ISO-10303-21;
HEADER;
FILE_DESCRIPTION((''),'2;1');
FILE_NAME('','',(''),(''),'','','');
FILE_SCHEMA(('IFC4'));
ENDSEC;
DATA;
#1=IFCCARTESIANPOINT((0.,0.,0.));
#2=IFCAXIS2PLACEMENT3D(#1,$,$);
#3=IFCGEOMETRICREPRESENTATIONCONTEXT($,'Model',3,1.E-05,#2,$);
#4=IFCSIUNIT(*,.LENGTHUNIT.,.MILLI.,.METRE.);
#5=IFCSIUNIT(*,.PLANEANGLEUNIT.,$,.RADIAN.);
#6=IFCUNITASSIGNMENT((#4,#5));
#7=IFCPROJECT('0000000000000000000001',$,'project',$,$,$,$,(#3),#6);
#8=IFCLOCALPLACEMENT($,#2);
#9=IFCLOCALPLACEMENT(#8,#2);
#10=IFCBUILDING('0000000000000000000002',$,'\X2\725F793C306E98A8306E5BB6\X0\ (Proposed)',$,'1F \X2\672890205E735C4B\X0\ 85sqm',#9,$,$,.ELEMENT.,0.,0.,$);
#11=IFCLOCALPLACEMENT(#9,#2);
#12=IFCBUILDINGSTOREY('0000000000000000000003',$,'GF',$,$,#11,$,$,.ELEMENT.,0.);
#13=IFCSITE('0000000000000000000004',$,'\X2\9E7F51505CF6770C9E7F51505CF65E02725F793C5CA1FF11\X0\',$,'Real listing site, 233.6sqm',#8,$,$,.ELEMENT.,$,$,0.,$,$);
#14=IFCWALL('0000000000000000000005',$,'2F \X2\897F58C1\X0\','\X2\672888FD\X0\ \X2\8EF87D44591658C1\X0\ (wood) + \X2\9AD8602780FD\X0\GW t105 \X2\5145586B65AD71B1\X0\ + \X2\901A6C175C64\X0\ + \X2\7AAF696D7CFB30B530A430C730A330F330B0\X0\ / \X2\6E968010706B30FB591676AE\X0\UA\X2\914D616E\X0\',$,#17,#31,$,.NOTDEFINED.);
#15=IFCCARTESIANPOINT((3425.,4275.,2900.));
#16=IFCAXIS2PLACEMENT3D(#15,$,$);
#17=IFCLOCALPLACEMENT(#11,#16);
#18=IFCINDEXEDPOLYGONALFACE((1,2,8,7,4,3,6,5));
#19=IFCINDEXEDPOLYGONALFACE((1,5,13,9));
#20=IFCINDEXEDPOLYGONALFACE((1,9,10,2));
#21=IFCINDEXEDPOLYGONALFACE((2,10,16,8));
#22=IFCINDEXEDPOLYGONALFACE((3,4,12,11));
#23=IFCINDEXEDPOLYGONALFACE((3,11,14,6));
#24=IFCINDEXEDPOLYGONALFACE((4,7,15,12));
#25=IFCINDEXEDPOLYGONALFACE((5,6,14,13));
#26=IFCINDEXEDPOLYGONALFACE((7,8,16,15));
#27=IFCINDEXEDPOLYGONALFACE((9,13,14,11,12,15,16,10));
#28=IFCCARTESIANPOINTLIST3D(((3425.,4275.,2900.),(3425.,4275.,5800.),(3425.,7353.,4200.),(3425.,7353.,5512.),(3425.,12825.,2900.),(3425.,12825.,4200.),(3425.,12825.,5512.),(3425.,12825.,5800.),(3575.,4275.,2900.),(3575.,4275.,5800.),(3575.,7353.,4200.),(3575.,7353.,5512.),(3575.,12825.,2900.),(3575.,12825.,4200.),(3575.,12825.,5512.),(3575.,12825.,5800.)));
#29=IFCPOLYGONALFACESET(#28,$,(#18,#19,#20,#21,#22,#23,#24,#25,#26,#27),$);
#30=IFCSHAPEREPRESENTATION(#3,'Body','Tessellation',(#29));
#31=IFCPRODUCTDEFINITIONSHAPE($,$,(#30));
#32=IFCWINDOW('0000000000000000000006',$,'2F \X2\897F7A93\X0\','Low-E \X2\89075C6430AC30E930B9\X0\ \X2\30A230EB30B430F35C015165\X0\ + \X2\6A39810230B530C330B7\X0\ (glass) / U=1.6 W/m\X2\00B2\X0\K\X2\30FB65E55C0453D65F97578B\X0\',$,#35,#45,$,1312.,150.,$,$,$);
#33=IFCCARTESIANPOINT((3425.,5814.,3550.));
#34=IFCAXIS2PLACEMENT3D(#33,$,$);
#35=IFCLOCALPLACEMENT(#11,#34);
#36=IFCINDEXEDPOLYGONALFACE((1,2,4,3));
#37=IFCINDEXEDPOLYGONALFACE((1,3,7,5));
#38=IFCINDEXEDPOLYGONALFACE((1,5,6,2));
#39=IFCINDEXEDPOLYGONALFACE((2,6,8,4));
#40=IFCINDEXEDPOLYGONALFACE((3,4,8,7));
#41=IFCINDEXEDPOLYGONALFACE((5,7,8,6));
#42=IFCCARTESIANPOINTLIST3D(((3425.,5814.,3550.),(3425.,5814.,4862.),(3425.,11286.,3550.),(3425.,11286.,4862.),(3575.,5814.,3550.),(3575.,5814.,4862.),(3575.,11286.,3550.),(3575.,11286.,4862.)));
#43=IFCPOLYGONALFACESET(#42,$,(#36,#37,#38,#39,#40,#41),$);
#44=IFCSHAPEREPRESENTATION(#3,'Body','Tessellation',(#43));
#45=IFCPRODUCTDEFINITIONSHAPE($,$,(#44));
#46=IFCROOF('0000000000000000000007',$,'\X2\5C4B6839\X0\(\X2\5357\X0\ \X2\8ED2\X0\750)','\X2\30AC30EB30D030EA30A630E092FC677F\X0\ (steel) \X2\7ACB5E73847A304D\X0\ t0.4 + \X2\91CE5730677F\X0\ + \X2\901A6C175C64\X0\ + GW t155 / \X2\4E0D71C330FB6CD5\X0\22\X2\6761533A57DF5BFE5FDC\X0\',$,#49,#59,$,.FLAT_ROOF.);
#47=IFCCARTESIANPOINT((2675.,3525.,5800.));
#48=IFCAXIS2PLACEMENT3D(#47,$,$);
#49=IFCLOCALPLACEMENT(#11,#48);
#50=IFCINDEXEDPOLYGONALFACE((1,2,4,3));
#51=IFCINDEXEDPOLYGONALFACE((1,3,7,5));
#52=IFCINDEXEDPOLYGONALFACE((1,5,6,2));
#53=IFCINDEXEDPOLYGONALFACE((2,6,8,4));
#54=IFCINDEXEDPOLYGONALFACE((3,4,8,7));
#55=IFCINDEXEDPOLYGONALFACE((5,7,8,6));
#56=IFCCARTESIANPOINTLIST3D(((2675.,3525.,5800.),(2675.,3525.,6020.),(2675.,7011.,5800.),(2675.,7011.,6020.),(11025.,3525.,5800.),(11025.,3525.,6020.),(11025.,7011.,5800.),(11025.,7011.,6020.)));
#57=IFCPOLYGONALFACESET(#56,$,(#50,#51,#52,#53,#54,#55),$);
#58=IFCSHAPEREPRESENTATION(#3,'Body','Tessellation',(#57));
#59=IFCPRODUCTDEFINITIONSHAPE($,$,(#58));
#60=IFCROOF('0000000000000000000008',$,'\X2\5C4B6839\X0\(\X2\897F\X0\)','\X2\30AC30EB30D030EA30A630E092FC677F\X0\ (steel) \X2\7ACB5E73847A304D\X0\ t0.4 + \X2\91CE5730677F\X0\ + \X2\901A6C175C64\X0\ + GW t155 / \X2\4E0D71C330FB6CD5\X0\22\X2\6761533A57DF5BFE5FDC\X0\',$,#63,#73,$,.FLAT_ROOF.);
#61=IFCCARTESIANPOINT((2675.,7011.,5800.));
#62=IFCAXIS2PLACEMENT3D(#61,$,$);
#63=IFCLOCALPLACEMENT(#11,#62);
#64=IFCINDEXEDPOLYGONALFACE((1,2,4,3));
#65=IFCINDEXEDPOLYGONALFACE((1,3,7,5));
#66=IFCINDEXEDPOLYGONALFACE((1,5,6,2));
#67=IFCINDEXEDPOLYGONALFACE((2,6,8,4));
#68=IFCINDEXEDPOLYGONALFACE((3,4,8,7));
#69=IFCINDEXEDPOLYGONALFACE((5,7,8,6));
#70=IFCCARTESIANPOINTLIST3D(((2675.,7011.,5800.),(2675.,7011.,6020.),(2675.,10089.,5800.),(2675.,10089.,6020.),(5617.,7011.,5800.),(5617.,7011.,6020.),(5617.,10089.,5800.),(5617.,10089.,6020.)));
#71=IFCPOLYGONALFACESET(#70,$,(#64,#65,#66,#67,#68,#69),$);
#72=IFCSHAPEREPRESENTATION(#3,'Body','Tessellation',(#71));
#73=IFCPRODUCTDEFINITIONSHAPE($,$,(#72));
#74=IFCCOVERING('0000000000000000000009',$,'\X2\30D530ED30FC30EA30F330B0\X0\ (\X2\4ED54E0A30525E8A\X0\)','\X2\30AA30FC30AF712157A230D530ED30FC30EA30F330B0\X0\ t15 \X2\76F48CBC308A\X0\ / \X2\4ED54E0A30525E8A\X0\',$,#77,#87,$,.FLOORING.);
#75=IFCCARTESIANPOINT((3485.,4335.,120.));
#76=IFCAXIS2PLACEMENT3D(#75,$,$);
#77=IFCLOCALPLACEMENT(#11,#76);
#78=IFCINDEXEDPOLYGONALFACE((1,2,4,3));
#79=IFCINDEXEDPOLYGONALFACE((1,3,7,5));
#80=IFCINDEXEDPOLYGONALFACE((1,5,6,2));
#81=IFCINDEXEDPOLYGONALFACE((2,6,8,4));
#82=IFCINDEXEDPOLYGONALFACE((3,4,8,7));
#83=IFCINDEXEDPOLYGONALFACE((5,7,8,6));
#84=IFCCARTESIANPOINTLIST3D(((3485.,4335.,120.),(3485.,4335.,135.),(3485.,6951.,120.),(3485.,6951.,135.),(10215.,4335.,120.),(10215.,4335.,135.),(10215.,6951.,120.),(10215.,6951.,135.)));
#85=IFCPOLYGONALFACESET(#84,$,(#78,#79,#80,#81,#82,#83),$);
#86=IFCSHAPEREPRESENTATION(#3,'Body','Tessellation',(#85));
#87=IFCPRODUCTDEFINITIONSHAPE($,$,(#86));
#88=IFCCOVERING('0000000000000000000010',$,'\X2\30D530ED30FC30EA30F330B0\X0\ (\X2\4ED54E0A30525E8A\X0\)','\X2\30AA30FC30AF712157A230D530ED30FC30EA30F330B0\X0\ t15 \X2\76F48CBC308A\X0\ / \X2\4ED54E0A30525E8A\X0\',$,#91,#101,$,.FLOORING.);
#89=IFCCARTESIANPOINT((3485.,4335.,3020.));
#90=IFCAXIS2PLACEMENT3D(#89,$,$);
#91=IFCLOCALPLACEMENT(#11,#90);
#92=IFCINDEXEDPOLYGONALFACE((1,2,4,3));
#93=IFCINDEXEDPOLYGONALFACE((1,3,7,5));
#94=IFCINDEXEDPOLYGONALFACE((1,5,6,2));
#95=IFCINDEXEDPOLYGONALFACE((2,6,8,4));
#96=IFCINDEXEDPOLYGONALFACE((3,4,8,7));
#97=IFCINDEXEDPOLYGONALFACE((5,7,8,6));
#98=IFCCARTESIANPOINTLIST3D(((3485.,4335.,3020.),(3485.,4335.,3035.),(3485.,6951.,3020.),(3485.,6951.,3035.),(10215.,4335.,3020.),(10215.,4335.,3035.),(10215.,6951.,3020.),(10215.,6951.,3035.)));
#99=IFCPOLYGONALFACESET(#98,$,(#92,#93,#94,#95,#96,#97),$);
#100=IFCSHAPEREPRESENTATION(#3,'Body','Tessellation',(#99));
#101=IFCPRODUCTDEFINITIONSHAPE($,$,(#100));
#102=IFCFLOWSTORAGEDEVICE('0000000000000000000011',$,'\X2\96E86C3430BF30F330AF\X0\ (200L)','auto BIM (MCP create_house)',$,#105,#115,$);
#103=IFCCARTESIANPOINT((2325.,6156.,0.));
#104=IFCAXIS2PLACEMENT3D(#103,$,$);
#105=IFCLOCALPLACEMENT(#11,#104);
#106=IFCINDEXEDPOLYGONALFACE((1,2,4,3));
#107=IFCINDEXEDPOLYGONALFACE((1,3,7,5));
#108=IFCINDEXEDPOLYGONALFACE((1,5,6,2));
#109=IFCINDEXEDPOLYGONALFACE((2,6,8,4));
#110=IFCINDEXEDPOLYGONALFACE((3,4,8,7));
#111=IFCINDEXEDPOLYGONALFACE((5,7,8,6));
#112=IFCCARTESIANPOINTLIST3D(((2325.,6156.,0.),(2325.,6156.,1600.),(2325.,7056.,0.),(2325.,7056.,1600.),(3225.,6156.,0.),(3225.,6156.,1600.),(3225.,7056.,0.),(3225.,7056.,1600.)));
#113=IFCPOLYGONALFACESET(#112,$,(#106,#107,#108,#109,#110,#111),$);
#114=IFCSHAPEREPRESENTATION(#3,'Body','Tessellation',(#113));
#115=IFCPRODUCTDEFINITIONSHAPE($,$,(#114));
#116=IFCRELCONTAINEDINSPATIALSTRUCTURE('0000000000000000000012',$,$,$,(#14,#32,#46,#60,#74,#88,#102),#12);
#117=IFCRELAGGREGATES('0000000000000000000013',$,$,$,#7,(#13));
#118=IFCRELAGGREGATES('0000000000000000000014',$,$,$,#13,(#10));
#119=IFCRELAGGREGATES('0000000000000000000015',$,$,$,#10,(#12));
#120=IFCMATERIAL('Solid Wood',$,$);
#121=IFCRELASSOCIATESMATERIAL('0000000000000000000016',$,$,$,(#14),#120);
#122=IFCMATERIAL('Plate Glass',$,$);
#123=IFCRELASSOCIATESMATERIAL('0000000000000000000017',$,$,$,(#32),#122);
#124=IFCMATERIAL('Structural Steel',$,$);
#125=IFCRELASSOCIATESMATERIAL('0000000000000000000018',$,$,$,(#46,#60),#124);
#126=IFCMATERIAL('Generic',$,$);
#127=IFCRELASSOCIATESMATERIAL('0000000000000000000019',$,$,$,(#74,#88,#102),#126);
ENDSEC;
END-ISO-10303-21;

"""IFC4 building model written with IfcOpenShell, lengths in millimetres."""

from ifc_helpers import new_model, si_unit, frame, frame_2d, origin, place, context, project, spatial, rectangle, extrude, material, element, fill, save


model = new_model("IFC4")

# Units and contexts
model_context = context("Model", 3, precision=1e-05, world=origin())
ifc_project = project(units=[si_unit("LENGTHUNIT", "METRE", prefix="MILLI"), si_unit("PLANEANGLEUNIT", "RADIAN")], contexts=[model_context])

# Site, building, storey
site_placement = place(None, origin())
site = spatial("IfcSite", under=ifc_project, at=site_placement, Name="鹿児島県鹿児島市牟礼岡１", ObjectType="Real listing site, 233.6sqm", CompositionType="ELEMENT", RefElevation=0.0)
building_placement = place(site_placement, origin())
building = spatial("IfcBuilding", under=site, at=building_placement, Name="牟礼の風の家 (Proposed)", ObjectType="1F 木造平屋 85sqm", CompositionType="ELEMENT", ElevationOfRefHeight=0.0, ElevationOfTerrain=0.0)
storey_placement = place(building_placement, origin())
storey = spatial("IfcBuildingStorey", under=building, at=storey_placement, Name="GF", CompositionType="ELEMENT", Elevation=0.0)

# Shared definitions
ifc_material_1 = material(Name="Solid Wood")
ifc_material_2 = material(Name="Generic")

# Shared definitions
ifc_material_3 = material(Name="Plate Glass")

# Wall, opening, window
wall_1_placement = place(storey_placement, frame((3425.0, 4275.0, 2900.0)))
wall_1 = element("IfcWall", 1, at=wall_1_placement, inside=storey, material=ifc_material_1, Name="2F 西壁", Description="木製 軸組外壁 (wood) + 高性能GW t105 充填断熱 + 通気層 + 窯業系サイディング / 準耐火・外皮UA配慮", PredefinedType="NOTDEFINED", context=model_context, shape_type="SweptSolid", body=[
    extrude(rectangle(XDim=150.0, YDim=8550.0, at=frame_2d((75.0, 4275.0))), frame((3425.0, 4275.0, 2900.0)), (0.0, 0.0, 1.0), 2900.0),
])
opening_1_placement = place(storey_placement, frame((3425.0, 5814.0, 3550.0)))
opening_1 = element("IfcOpeningElement", 2, at=opening_1_placement, cuts=wall_1, PredefinedType="NOTDEFINED", context=model_context, shape_type="SweptSolid", body=[
    extrude(rectangle(XDim=150.0, YDim=5472.0, at=frame_2d((75.0, 2736.0))), frame((3425.0, 5814.0, 3550.0)), (0.0, 0.0, 1.0), 1312.0),
])
window_1_placement = place(storey_placement, frame((3425.0, 5814.0, 3550.0)))
window_1 = element("IfcWindow", 3, at=window_1_placement, inside=storey, material=ifc_material_3, Name="2F 西窓", Description="Low-E 複層ガラス アルゴン封入 + 樹脂サッシ (glass) / U=1.6 W/m²K・日射取得型", OverallHeight=1312.0, OverallWidth=150.0, context=model_context, shape_type="SweptSolid", body=[
    extrude(rectangle(XDim=150.0, YDim=5472.0, at=frame_2d((75.0, 2736.0))), frame((3425.0, 5814.0, 3550.0)), (0.0, 0.0, 1.0), 1312.0),
])
fill(opening_1, window_1)

# Roofs
ifc_material_4 = material(Name="Structural Steel")
roof_1_placement = place(storey_placement, frame((2675.0, 3525.0, 5800.0)))
element("IfcRoof", 4, at=roof_1_placement, inside=storey, material=ifc_material_4, Name="屋根(南 軒750)", Description="ガルバリウム鋼板 (steel) 立平葺き t0.4 + 野地板 + 通気層 + GW t155 / 不燃・法22条区域対応", PredefinedType="FLAT_ROOF", context=model_context, shape_type="SweptSolid", body=[
    extrude(rectangle(XDim=8350.0, YDim=3486.0, at=frame_2d((4175.0, 1743.0))), frame((2675.0, 3525.0, 5800.0)), (0.0, 0.0, 1.0), 220.0),
])
roof_2_placement = place(storey_placement, frame((2675.0, 7011.0, 5800.0)))
element("IfcRoof", 5, at=roof_2_placement, inside=storey, material=ifc_material_4, Name="屋根(西)", Description="ガルバリウム鋼板 (steel) 立平葺き t0.4 + 野地板 + 通気層 + GW t155 / 不燃・法22条区域対応", PredefinedType="FLAT_ROOF", context=model_context, shape_type="SweptSolid", body=[
    extrude(rectangle(XDim=2942.0, YDim=3078.0, at=frame_2d((1471.0, 1539.0))), frame((2675.0, 7011.0, 5800.0)), (0.0, 0.0, 1.0), 220.0),
])

# Coverings
covering_1_placement = place(storey_placement, frame((3485.0, 4335.0, 120.0)))
element("IfcCovering", 6, at=covering_1_placement, inside=storey, material=ifc_material_2, Name="フローリング (仕上げ床)", Description="オーク無垢フローリング t15 直貼り / 仕上げ床", PredefinedType="FLOORING", context=model_context, shape_type="SweptSolid", body=[
    extrude(rectangle(XDim=6730.0, YDim=2616.0, at=frame_2d((3365.0, 1308.0))), frame((3485.0, 4335.0, 120.0)), (0.0, 0.0, 1.0), 15.0),
])
covering_2_placement = place(storey_placement, frame((3485.0, 4335.0, 3020.0)))
element("IfcCovering", 7, at=covering_2_placement, inside=storey, material=ifc_material_2, Name="フローリング (仕上げ床)", Description="オーク無垢フローリング t15 直貼り / 仕上げ床", PredefinedType="FLOORING", context=model_context, shape_type="SweptSolid", body=[
    extrude(rectangle(XDim=6730.0, YDim=2616.0, at=frame_2d((3365.0, 1308.0))), frame((3485.0, 4335.0, 3020.0)), (0.0, 0.0, 1.0), 15.0),
])

# Flow storage device
flow_storage_device_placement = place(storey_placement, frame((2325.0, 6156.0, 0.0)))
element("IfcFlowStorageDevice", 8, at=flow_storage_device_placement, inside=storey, material=ifc_material_2, Name="雨水タンク (200L)", Description="auto BIM (MCP create_house)", context=model_context, shape_type="SweptSolid", body=[
    extrude(rectangle(XDim=900.0, YDim=900.0, at=frame_2d((450.0, 450.0))), frame((2325.0, 6156.0, 0.0)), (0.0, 0.0, 1.0), 1600.0),
])

save(model, "model.ifc")
